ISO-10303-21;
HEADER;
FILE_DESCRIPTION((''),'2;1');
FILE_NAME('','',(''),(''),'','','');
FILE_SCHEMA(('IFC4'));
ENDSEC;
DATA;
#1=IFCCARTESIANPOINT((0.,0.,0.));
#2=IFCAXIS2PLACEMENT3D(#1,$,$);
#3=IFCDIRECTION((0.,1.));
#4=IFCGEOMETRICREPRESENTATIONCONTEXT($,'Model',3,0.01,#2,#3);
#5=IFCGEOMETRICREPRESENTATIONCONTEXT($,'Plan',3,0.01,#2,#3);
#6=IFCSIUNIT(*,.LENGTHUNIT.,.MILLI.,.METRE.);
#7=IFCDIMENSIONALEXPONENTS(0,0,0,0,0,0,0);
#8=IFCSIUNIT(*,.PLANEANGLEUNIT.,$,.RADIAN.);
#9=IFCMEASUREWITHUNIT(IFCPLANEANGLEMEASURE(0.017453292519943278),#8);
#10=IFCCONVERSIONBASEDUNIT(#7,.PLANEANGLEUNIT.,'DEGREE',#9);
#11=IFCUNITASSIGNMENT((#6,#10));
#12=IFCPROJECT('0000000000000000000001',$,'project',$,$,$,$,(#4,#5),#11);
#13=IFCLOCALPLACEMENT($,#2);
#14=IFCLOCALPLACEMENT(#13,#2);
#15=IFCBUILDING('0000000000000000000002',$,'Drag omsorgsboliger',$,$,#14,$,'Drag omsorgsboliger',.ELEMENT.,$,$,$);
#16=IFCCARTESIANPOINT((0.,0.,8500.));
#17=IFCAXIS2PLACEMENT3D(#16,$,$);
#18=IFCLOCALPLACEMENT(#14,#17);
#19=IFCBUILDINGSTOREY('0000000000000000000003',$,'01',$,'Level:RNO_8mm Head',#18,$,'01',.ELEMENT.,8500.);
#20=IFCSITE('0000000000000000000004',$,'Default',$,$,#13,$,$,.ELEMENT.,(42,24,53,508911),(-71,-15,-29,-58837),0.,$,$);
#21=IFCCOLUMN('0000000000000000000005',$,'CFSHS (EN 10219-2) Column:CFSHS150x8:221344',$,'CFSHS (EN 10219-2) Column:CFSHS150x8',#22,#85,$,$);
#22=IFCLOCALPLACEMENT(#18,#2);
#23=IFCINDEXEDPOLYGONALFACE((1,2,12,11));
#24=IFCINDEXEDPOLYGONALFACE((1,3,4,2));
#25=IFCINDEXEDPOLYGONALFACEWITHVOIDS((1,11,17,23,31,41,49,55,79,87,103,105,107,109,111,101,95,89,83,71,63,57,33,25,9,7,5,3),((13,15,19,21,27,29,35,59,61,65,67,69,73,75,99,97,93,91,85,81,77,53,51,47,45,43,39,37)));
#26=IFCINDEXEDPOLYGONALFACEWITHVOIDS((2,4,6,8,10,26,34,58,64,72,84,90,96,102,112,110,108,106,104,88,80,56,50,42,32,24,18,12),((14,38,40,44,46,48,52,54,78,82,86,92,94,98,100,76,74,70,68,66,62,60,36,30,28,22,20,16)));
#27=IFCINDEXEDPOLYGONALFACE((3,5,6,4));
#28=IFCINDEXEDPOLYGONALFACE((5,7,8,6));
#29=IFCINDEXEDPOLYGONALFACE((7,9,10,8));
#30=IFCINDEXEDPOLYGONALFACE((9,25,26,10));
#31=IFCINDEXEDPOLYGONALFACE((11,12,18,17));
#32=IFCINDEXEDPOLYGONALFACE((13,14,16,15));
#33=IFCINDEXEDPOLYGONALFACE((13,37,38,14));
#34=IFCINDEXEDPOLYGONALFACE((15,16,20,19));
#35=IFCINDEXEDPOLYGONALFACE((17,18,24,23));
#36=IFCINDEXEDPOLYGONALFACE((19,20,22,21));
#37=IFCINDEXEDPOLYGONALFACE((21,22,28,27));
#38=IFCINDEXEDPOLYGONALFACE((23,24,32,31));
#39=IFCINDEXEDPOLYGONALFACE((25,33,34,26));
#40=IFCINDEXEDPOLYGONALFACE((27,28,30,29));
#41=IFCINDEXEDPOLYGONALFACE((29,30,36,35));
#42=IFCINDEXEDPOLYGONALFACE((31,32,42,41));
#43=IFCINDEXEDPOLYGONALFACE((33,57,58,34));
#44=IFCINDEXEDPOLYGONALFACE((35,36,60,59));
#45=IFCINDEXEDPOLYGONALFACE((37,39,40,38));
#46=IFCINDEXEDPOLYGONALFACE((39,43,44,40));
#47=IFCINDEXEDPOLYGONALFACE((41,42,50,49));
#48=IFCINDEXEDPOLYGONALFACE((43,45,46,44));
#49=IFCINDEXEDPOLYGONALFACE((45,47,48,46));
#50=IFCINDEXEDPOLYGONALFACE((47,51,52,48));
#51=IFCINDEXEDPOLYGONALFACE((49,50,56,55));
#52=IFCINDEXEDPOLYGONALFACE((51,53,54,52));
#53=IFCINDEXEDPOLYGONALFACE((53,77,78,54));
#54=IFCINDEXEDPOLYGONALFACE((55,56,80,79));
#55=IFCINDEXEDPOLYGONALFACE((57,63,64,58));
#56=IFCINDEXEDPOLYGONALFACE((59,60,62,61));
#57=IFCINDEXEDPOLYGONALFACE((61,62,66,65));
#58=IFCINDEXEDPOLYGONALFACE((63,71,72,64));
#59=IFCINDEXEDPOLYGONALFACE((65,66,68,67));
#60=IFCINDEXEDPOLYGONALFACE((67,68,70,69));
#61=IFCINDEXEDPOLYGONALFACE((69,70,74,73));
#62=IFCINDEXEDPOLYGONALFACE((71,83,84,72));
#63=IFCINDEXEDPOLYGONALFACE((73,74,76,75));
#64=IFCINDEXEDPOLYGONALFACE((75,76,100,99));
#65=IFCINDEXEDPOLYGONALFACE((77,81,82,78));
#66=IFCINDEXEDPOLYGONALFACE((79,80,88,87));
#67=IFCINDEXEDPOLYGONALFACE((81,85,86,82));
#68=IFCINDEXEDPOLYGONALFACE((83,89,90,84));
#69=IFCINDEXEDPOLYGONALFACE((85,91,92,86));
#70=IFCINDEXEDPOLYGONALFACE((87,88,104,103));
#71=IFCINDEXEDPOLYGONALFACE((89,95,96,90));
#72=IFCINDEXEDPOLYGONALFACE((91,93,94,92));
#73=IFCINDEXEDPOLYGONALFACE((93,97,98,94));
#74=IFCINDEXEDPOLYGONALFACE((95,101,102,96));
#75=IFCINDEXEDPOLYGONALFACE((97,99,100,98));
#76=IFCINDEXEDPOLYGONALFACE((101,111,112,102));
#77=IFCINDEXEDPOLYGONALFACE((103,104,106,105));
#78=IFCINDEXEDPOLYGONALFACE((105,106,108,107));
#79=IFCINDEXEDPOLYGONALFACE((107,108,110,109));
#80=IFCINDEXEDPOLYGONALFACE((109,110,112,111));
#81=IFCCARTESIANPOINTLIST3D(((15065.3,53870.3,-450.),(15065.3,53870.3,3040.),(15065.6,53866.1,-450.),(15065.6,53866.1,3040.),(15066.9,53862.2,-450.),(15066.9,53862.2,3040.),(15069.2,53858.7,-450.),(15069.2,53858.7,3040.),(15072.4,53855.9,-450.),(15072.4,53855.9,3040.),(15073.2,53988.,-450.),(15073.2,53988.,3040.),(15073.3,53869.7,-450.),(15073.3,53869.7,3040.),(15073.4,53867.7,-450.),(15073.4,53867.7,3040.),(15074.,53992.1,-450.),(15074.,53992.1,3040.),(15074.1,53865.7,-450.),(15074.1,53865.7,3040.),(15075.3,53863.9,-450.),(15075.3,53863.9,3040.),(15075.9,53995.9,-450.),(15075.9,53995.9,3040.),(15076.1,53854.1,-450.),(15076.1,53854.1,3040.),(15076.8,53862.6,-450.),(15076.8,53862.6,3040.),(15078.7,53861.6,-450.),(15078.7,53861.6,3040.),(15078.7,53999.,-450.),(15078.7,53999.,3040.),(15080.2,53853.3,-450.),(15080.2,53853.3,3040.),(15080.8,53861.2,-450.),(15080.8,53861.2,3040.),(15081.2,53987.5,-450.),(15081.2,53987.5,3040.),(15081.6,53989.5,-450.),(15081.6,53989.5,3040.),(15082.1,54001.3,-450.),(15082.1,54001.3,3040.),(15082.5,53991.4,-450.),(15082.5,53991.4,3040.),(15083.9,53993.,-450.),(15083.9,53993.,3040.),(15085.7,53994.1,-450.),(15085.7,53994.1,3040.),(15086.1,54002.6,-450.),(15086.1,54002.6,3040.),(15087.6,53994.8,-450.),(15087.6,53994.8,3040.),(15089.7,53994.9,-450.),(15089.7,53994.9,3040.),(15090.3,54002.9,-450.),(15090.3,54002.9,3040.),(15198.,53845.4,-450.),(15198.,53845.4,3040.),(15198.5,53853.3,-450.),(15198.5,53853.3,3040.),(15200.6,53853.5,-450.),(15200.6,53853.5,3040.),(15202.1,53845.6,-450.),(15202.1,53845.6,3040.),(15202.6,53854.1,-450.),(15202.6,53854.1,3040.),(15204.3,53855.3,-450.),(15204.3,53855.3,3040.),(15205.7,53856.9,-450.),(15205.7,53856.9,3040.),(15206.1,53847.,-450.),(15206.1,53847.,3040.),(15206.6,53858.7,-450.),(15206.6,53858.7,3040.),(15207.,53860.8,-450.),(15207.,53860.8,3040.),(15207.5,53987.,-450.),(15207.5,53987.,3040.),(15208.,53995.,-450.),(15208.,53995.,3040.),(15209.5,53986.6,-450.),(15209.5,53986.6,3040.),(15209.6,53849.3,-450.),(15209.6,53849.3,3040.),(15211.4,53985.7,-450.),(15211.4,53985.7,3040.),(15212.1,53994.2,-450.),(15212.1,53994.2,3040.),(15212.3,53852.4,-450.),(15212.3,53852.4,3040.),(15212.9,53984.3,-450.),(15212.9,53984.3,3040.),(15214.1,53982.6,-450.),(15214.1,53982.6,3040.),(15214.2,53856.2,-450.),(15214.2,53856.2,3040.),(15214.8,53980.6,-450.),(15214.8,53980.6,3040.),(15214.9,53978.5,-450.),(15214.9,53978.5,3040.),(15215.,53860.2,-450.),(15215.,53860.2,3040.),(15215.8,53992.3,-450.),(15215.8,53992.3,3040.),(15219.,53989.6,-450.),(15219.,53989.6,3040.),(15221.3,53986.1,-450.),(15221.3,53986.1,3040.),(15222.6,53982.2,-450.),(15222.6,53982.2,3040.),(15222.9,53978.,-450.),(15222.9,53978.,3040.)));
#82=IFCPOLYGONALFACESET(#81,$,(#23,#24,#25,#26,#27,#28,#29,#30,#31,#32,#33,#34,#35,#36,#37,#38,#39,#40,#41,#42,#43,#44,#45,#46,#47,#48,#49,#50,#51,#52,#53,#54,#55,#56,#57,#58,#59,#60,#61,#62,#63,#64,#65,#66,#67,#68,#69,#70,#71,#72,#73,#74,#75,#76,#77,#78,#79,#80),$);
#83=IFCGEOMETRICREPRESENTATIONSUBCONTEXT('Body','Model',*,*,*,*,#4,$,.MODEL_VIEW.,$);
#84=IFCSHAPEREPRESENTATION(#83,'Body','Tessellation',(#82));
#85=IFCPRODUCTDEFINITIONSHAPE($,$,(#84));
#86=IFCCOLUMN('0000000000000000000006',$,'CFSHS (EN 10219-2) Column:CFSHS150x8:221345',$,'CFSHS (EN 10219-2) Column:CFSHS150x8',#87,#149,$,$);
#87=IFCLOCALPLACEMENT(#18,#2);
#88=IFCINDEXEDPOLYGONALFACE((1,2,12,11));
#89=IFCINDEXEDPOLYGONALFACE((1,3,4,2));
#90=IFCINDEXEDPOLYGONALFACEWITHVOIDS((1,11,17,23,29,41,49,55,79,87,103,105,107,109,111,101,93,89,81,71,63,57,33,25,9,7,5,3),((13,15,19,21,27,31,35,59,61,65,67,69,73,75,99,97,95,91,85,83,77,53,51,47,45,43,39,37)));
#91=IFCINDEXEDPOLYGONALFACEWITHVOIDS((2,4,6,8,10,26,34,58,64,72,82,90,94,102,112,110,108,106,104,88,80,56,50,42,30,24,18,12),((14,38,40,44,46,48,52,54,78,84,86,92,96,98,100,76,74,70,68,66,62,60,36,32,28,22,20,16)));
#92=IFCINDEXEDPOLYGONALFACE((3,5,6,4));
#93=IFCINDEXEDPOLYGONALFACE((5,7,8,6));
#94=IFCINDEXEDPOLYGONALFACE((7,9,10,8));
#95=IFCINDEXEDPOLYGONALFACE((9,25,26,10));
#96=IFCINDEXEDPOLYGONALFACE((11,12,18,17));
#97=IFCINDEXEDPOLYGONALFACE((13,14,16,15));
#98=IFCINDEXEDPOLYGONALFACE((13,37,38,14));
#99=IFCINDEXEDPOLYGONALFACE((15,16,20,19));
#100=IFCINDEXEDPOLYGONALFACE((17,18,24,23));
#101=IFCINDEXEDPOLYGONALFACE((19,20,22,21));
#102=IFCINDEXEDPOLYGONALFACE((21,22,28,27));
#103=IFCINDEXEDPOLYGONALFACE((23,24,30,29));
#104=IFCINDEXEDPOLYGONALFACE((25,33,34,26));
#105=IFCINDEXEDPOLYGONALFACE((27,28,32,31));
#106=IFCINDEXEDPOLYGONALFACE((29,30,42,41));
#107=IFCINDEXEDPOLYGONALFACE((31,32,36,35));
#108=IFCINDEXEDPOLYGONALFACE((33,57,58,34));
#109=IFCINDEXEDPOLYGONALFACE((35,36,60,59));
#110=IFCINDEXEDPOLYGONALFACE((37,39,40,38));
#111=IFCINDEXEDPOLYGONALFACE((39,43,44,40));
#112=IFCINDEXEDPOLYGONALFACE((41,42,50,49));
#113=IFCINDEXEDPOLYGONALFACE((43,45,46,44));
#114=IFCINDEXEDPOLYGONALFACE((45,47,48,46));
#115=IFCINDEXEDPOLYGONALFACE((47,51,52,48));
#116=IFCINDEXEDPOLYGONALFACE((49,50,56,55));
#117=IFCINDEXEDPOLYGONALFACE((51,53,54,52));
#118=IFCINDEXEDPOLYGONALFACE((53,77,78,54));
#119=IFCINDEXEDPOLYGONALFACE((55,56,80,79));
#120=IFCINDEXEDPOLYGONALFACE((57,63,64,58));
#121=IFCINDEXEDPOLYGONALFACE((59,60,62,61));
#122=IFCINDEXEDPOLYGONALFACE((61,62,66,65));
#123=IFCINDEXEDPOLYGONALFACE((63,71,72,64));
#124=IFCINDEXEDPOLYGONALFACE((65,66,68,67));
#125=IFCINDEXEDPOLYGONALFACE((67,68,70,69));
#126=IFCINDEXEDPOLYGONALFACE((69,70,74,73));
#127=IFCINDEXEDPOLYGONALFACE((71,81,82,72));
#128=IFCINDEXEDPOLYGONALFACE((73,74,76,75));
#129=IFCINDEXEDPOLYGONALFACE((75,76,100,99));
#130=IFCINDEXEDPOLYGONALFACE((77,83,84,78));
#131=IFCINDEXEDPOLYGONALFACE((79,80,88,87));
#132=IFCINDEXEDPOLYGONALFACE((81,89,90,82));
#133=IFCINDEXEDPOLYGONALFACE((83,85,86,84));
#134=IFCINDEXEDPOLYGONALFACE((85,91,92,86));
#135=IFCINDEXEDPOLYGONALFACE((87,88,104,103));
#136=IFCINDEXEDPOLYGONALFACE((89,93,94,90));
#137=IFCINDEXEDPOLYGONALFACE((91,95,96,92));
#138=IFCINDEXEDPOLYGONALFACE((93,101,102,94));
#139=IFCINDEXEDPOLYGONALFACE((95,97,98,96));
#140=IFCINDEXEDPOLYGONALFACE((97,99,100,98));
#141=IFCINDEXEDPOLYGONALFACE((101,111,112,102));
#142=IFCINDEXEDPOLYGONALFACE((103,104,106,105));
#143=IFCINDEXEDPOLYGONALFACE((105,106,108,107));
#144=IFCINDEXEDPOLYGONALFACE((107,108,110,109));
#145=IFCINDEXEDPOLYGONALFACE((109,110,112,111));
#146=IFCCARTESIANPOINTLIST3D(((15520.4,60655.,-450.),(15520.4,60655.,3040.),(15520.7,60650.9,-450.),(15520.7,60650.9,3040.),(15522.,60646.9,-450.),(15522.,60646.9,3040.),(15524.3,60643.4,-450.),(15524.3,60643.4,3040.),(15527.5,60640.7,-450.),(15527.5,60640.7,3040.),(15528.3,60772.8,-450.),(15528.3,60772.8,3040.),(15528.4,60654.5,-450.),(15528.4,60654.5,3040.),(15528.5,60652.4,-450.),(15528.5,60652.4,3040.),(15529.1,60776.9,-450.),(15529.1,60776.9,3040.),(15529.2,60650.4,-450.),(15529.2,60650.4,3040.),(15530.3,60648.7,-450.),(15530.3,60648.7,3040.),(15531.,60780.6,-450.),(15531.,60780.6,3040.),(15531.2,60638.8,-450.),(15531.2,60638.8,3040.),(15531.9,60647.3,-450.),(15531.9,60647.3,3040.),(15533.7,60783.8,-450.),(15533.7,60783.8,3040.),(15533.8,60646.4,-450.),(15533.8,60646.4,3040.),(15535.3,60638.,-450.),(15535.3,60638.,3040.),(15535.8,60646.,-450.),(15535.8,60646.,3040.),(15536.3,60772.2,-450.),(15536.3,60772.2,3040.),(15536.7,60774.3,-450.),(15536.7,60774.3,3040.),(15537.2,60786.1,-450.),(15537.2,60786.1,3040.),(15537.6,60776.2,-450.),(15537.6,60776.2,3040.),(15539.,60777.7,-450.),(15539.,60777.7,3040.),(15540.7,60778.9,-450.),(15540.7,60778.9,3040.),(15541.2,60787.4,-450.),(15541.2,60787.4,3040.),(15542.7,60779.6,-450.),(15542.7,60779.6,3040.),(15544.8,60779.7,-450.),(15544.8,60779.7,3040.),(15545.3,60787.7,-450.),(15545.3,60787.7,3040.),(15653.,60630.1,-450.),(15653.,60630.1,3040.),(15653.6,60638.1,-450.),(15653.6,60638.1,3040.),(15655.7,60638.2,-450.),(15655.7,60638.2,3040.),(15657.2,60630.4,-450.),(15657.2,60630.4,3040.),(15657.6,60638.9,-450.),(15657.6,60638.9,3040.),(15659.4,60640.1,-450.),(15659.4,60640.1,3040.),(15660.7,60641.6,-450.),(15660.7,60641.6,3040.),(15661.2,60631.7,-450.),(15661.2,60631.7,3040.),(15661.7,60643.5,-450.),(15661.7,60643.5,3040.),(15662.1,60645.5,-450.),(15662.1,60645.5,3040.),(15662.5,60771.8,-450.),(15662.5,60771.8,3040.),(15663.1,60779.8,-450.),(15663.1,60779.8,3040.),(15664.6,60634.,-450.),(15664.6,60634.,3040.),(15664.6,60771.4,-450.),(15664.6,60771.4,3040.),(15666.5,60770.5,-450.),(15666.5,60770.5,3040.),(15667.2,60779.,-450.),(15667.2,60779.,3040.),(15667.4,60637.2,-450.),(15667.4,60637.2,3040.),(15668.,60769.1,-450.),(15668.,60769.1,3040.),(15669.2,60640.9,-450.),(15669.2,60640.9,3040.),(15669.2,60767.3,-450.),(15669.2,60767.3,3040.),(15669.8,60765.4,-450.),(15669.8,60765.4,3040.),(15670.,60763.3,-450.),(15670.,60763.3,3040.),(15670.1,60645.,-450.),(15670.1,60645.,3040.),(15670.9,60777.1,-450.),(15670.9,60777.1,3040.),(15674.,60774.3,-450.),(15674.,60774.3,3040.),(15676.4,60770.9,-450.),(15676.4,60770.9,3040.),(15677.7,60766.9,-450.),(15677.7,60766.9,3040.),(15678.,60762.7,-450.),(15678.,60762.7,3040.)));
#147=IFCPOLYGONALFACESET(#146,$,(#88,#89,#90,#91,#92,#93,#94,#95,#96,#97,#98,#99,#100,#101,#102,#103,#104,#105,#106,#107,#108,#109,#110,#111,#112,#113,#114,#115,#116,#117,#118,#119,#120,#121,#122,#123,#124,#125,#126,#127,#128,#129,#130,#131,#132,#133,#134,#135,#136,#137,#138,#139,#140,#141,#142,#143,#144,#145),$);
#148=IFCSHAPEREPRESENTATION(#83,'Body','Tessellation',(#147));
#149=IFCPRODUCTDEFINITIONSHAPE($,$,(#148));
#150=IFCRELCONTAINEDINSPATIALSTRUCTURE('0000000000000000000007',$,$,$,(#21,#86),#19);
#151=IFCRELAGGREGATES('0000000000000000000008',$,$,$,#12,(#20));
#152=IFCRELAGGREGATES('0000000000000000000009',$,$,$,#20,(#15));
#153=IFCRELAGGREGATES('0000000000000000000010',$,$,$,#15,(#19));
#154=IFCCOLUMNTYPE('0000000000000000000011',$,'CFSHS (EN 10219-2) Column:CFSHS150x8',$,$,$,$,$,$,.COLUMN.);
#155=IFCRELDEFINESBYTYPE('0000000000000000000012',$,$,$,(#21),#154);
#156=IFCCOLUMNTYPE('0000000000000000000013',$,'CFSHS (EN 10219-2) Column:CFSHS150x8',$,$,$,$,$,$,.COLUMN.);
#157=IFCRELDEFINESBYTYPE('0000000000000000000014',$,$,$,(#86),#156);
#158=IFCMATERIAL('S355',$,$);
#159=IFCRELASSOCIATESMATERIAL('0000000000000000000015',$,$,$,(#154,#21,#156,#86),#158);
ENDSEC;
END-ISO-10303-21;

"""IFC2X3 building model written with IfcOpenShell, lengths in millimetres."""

from ifc_helpers import new_model, entity, si_unit, converted_unit, direction, frame, frame_2d, origin, place, context, subcontext, project, spatial, polyline, circle_curve, parameter, trimmed, segment, composite_curve, outline, extrude, source, transform, mapped, material, type_object, type_shapes, element, save


model = new_model("IFC2X3")

# Units and contexts
model_context = context("Model", 3, precision=0.01, world=origin(), true_north=direction((0.0, 1.0)))
plan_context = context("Plan", 3, precision=0.01, world=origin(), true_north=direction((0.0, 1.0)))
body_context = subcontext(model_context, "Body", "Model", "MODEL_VIEW")
ifc_project = project(units=[si_unit("LENGTHUNIT", "METRE", prefix="MILLI"), converted_unit("PLANEANGLEUNIT", "DEGREE", entity("IfcPlaneAngleMeasure", 0.017453292519943278), si_unit("PLANEANGLEUNIT", "RADIAN"), dimensions=[0, 0, 0, 0, 0, 0, 0])], contexts=[model_context, plan_context])

# Site, building, storey
site_placement = place(None, origin())
site = spatial("IfcSite", under=ifc_project, at=site_placement, Name="Default", CompositionType="ELEMENT", RefLatitude=(42, 24, 53, 508911), RefLongitude=(-71, -15, -29, -58837), RefElevation=0.0)
building_placement = place(site_placement, origin())
building = spatial("IfcBuilding", under=site, at=building_placement, Name="Drag omsorgsboliger", LongName="Drag omsorgsboliger", CompositionType="ELEMENT")
storey_placement = place(building_placement, frame((0.0, 0.0, 8500.0)))
storey = spatial("IfcBuildingStorey", under=building, at=storey_placement, Name="01", ObjectType="Level:RNO_8mm Head", LongName="01", CompositionType="ELEMENT", Elevation=8500.0)

# Columns
ifc_material = material(Name="S355")
column_type_1 = type_object("IfcColumnType", Name="CFSHS (EN 10219-2) Column:CFSHS150x8", PredefinedType="COLUMN", material=ifc_material)
shared_shape_1 = source(origin(), body_context, "Body", "SweptSolid", [
    extrude(outline(composite_curve([segment(polyline([(-59.0, -75.0), (59.0, -75.0)]), True, "CONTINUOUS"), segment(trimmed(circle_curve(frame_2d((59.0, -59.0), x_axis=(-1.0, 0.0)), 16.0), [parameter(90.0)], [parameter(180.0)], True, "PARAMETER"), True, "CONTINUOUS"), segment(polyline([(75.0, -59.0), (75.0, 59.0)]), True, "CONTINUOUS"), segment(trimmed(circle_curve(frame_2d((59.0, 59.0), x_axis=(-1.0, 0.0)), 16.0), [parameter(180.0)], [parameter(270.0)], True, "PARAMETER"), True, "CONTINUOUS"), segment(polyline([(59.0, 75.0), (-59.0, 75.0)]), True, "CONTINUOUS"), segment(trimmed(circle_curve(frame_2d((-59.0, 59.0), x_axis=(-1.0, 0.0)), 16.0), [parameter(270.0)], [parameter(360.0)], True, "PARAMETER"), True, "CONTINUOUS"), segment(polyline([(-75.0, 59.0), (-75.0, -59.0)]), True, "CONTINUOUS"), segment(trimmed(circle_curve(frame_2d((-59.0, -59.0), x_axis=(-1.0, 0.0)), 16.0), [parameter(360.0)], [parameter(90.0)], True, "PARAMETER"), True, "CONTINUOUS")], self_intersect=False), holes=[composite_curve([segment(trimmed(circle_curve(frame_2d((-59.0, -59.0), x_axis=(-1.0, 0.0)), 8.0), [parameter(360.0)], [parameter(90.0)], True, "PARAMETER"), False, "CONTINUOUS"), segment(polyline([(-67.0, -59.0), (-67.0, 59.0)]), True, "CONTINUOUS"), segment(trimmed(circle_curve(frame_2d((-59.0, 59.0), x_axis=(-1.0, 0.0)), 8.0), [parameter(270.0)], [parameter(360.0)], True, "PARAMETER"), False, "CONTINUOUS"), segment(polyline([(-59.0, 67.0), (59.0, 67.0)]), True, "CONTINUOUS"), segment(trimmed(circle_curve(frame_2d((59.0, 59.0), x_axis=(-1.0, 0.0)), 8.0), [parameter(180.0)], [parameter(270.0)], True, "PARAMETER"), False, "CONTINUOUS"), segment(polyline([(67.0, 59.0), (67.0, -59.0)]), True, "CONTINUOUS"), segment(trimmed(circle_curve(frame_2d((59.0, -59.0), x_axis=(-1.0, 0.0)), 8.0), [parameter(90.0)], [parameter(180.0)], True, "PARAMETER"), False, "CONTINUOUS"), segment(polyline([(59.0, -67.0), (-59.0, -67.0)]), True, "CONTINUOUS")], self_intersect=False)]), frame((15144.1, 53924.1, 8050.0), z_axis=(0.0, 0.0, 1.0), x_axis=(-0.997758, 0.066923, 0.0)), (0.0, 0.0, 1.0), 3490.0),
])
type_shapes(column_type_1, [shared_shape_1])
column_1_placement = place(storey_placement, frame((0.0, 0.0, -8500.0)))
element("IfcColumn", 1, at=column_1_placement, inside=storey, type_object=column_type_1, material=ifc_material, Name="CFSHS (EN 10219-2) Column:CFSHS150x8:221344", ObjectType="CFSHS (EN 10219-2) Column:CFSHS150x8", context=body_context, shape_type="MappedRepresentation", body=[
    mapped(shared_shape_1, transform((0.0, 0.0, 0.0), scale=1.0)),
])
column_type_2 = type_object("IfcColumnType", Name="CFSHS (EN 10219-2) Column:CFSHS150x8", PredefinedType="COLUMN", material=ifc_material)
shared_shape_2 = source(origin(), body_context, "Body", "SweptSolid", [
    extrude(outline(composite_curve([segment(polyline([(-59.0, -75.0), (59.0, -75.0)]), True, "CONTINUOUS"), segment(trimmed(circle_curve(frame_2d((59.0, -59.0), x_axis=(-1.0, 0.0)), 16.0), [parameter(90.0)], [parameter(180.0)], True, "PARAMETER"), True, "CONTINUOUS"), segment(polyline([(75.0, -59.0), (75.0, 59.0)]), True, "CONTINUOUS"), segment(trimmed(circle_curve(frame_2d((59.0, 59.0), x_axis=(-1.0, 0.0)), 16.0), [parameter(180.0)], [parameter(270.0)], True, "PARAMETER"), True, "CONTINUOUS"), segment(polyline([(59.0, 75.0), (-59.0, 75.0)]), True, "CONTINUOUS"), segment(trimmed(circle_curve(frame_2d((-59.0, 59.0), x_axis=(-1.0, 0.0)), 16.0), [parameter(270.0)], [parameter(360.0)], True, "PARAMETER"), True, "CONTINUOUS"), segment(polyline([(-75.0, 59.0), (-75.0, -59.0)]), True, "CONTINUOUS"), segment(trimmed(circle_curve(frame_2d((-59.0, -59.0), x_axis=(-1.0, 0.0)), 16.0), [parameter(360.0)], [parameter(90.0)], True, "PARAMETER"), True, "CONTINUOUS")], self_intersect=False), holes=[composite_curve([segment(trimmed(circle_curve(frame_2d((-59.0, -59.0), x_axis=(-1.0, 0.0)), 8.0), [parameter(360.0)], [parameter(90.0)], True, "PARAMETER"), False, "CONTINUOUS"), segment(polyline([(-67.0, -59.0), (-67.0, 59.0)]), True, "CONTINUOUS"), segment(trimmed(circle_curve(frame_2d((-59.0, 59.0), x_axis=(-1.0, 0.0)), 8.0), [parameter(270.0)], [parameter(360.0)], True, "PARAMETER"), False, "CONTINUOUS"), segment(polyline([(-59.0, 67.0), (59.0, 67.0)]), True, "CONTINUOUS"), segment(trimmed(circle_curve(frame_2d((59.0, 59.0), x_axis=(-1.0, 0.0)), 8.0), [parameter(180.0)], [parameter(270.0)], True, "PARAMETER"), False, "CONTINUOUS"), segment(polyline([(67.0, 59.0), (67.0, -59.0)]), True, "CONTINUOUS"), segment(trimmed(circle_curve(frame_2d((59.0, -59.0), x_axis=(-1.0, 0.0)), 8.0), [parameter(90.0)], [parameter(180.0)], True, "PARAMETER"), False, "CONTINUOUS"), segment(polyline([(59.0, -67.0), (-59.0, -67.0)]), True, "CONTINUOUS")], self_intersect=False)]), frame((15599.2, 60708.9, 8050.0), z_axis=(0.0, 0.0, 1.0), x_axis=(-0.997758, 0.066923, 0.0)), (0.0, 0.0, 1.0), 3490.0),
])
type_shapes(column_type_2, [shared_shape_2])
column_2_placement = place(storey_placement, frame((0.0, 0.0, -8500.0)))
element("IfcColumn", 2, at=column_2_placement, inside=storey, type_object=column_type_2, material=ifc_material, Name="CFSHS (EN 10219-2) Column:CFSHS150x8:221345", ObjectType="CFSHS (EN 10219-2) Column:CFSHS150x8", context=body_context, shape_type="MappedRepresentation", body=[
    mapped(shared_shape_2, transform((0.0, 0.0, 0.0), scale=1.0)),
])

save(model, "model.ifc")
